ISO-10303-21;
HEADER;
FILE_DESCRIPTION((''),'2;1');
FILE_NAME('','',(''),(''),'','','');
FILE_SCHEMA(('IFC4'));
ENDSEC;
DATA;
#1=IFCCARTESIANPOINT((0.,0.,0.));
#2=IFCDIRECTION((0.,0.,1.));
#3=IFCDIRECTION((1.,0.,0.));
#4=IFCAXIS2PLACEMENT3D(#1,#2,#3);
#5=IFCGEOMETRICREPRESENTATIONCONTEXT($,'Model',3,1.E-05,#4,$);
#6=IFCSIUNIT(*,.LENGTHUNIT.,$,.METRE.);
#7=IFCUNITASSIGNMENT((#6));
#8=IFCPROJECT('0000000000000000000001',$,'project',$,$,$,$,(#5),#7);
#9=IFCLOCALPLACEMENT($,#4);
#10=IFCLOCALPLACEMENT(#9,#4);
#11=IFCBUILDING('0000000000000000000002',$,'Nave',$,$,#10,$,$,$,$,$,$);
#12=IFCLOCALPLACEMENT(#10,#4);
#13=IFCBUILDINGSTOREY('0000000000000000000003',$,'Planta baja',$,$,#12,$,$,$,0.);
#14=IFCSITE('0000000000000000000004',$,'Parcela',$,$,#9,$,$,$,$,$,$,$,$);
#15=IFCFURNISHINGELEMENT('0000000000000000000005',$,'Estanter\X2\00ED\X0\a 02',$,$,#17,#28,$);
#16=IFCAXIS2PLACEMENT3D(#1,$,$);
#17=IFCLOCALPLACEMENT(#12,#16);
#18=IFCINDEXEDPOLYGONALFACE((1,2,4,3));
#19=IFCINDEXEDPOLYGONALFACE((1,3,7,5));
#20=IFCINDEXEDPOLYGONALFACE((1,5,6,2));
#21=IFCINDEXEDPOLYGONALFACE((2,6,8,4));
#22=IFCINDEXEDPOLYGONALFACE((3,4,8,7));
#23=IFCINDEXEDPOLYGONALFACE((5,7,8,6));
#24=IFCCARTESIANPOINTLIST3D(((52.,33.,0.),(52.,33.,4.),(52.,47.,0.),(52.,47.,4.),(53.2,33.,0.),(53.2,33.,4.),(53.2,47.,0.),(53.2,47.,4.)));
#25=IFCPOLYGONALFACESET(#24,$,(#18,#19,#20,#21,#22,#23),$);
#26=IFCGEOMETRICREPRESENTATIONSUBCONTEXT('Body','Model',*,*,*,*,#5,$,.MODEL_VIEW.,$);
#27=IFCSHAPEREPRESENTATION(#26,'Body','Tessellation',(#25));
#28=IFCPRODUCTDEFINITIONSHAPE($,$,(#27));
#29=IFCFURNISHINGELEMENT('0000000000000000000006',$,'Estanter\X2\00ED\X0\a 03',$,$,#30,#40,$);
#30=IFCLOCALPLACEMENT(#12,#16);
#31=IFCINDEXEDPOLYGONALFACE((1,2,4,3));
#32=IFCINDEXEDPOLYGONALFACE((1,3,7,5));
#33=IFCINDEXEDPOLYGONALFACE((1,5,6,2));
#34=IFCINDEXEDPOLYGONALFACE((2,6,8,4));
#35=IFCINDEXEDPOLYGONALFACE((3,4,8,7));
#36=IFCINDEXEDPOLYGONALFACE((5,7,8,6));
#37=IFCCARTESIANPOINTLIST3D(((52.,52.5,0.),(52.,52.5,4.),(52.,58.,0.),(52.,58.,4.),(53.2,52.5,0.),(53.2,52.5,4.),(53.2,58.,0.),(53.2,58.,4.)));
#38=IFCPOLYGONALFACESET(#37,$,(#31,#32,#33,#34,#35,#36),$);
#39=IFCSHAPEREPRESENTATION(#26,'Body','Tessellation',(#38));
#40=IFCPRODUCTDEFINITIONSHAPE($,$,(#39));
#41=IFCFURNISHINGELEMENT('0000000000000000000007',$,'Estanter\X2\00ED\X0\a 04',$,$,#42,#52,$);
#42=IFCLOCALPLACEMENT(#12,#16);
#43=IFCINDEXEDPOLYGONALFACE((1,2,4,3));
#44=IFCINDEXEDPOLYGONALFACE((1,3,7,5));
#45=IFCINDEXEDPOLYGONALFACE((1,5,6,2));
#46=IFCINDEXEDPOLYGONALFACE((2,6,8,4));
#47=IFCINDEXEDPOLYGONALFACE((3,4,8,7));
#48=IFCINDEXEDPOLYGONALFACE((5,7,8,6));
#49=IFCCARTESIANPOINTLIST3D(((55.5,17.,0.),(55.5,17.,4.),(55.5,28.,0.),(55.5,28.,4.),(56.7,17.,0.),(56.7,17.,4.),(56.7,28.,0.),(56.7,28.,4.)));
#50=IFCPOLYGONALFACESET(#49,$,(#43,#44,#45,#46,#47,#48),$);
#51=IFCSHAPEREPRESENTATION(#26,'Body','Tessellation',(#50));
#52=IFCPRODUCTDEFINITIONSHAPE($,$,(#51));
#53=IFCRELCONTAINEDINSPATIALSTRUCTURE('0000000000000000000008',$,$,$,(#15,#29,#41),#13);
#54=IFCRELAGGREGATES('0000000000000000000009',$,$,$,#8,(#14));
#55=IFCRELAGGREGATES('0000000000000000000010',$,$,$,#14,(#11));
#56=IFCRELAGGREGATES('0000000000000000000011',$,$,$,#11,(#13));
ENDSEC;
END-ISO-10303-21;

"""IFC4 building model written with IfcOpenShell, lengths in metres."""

from ifc_helpers import new_model, si_unit, frame, origin_with_axes, place, context, subcontext, project, spatial, indexed_curve, outline, extrude, element, save


model = new_model("IFC4")

# Units and contexts
model_context = context("Model", 3, precision=1e-05, world=origin_with_axes())
body_context = subcontext(model_context, "Body", "Model", "MODEL_VIEW")
ifc_project = project(units=[si_unit("LENGTHUNIT", "METRE")], contexts=[model_context])

# Site, building, storey
site_placement = place(None, origin_with_axes())
site = spatial("IfcSite", under=ifc_project, at=site_placement, Name="Parcela")
building_placement = place(site_placement, origin_with_axes())
building = spatial("IfcBuilding", under=site, at=building_placement, Name="Nave")
storey_placement = place(building_placement, origin_with_axes())
storey = spatial("IfcBuildingStorey", under=building, at=storey_placement, Name="Planta baja", Elevation=0.0)

# Furnishing elements
furnishing_1_placement = place(storey_placement, frame((52.0, 33.0, 0.0), z_axis=(0.0, 0.0, 1.0), x_axis=(1.0, 0.0, 0.0)))
element("IfcFurnishingElement", 1, at=furnishing_1_placement, inside=storey, Name="Estantería 02", context=body_context, shape_type="SweptSolid", body=[
    extrude(outline(indexed_curve([(0.0, 0.0), (0.0, 14.0), (1.2, 14.0), (1.2, 0.0), (0.0, 0.0)], self_intersect=False)), origin_with_axes(), (0.0, 0.0, 1.0), 4.0),
])
furnishing_2_placement = place(storey_placement, frame((52.0, 52.5, 0.0), z_axis=(0.0, 0.0, 1.0), x_axis=(1.0, 0.0, 0.0)))
element("IfcFurnishingElement", 2, at=furnishing_2_placement, inside=storey, Name="Estantería 03", context=body_context, shape_type="SweptSolid", body=[
    extrude(outline(indexed_curve([(0.0, 0.0), (0.0, 5.5), (1.2, 5.5), (1.2, 0.0), (0.0, 0.0)], self_intersect=False)), origin_with_axes(), (0.0, 0.0, 1.0), 4.0),
])
furnishing_3_placement = place(storey_placement, frame((55.5, 17.0, 0.0), z_axis=(0.0, 0.0, 1.0), x_axis=(1.0, 0.0, 0.0)))
element("IfcFurnishingElement", 3, at=furnishing_3_placement, inside=storey, Name="Estantería 04", context=body_context, shape_type="SweptSolid", body=[
    extrude(outline(indexed_curve([(0.0, 0.0), (0.0, 11.0), (1.2, 11.0), (1.2, 0.0), (0.0, 0.0)], self_intersect=False)), origin_with_axes(), (0.0, 0.0, 1.0), 4.0),
])

save(model, "model.ifc")
